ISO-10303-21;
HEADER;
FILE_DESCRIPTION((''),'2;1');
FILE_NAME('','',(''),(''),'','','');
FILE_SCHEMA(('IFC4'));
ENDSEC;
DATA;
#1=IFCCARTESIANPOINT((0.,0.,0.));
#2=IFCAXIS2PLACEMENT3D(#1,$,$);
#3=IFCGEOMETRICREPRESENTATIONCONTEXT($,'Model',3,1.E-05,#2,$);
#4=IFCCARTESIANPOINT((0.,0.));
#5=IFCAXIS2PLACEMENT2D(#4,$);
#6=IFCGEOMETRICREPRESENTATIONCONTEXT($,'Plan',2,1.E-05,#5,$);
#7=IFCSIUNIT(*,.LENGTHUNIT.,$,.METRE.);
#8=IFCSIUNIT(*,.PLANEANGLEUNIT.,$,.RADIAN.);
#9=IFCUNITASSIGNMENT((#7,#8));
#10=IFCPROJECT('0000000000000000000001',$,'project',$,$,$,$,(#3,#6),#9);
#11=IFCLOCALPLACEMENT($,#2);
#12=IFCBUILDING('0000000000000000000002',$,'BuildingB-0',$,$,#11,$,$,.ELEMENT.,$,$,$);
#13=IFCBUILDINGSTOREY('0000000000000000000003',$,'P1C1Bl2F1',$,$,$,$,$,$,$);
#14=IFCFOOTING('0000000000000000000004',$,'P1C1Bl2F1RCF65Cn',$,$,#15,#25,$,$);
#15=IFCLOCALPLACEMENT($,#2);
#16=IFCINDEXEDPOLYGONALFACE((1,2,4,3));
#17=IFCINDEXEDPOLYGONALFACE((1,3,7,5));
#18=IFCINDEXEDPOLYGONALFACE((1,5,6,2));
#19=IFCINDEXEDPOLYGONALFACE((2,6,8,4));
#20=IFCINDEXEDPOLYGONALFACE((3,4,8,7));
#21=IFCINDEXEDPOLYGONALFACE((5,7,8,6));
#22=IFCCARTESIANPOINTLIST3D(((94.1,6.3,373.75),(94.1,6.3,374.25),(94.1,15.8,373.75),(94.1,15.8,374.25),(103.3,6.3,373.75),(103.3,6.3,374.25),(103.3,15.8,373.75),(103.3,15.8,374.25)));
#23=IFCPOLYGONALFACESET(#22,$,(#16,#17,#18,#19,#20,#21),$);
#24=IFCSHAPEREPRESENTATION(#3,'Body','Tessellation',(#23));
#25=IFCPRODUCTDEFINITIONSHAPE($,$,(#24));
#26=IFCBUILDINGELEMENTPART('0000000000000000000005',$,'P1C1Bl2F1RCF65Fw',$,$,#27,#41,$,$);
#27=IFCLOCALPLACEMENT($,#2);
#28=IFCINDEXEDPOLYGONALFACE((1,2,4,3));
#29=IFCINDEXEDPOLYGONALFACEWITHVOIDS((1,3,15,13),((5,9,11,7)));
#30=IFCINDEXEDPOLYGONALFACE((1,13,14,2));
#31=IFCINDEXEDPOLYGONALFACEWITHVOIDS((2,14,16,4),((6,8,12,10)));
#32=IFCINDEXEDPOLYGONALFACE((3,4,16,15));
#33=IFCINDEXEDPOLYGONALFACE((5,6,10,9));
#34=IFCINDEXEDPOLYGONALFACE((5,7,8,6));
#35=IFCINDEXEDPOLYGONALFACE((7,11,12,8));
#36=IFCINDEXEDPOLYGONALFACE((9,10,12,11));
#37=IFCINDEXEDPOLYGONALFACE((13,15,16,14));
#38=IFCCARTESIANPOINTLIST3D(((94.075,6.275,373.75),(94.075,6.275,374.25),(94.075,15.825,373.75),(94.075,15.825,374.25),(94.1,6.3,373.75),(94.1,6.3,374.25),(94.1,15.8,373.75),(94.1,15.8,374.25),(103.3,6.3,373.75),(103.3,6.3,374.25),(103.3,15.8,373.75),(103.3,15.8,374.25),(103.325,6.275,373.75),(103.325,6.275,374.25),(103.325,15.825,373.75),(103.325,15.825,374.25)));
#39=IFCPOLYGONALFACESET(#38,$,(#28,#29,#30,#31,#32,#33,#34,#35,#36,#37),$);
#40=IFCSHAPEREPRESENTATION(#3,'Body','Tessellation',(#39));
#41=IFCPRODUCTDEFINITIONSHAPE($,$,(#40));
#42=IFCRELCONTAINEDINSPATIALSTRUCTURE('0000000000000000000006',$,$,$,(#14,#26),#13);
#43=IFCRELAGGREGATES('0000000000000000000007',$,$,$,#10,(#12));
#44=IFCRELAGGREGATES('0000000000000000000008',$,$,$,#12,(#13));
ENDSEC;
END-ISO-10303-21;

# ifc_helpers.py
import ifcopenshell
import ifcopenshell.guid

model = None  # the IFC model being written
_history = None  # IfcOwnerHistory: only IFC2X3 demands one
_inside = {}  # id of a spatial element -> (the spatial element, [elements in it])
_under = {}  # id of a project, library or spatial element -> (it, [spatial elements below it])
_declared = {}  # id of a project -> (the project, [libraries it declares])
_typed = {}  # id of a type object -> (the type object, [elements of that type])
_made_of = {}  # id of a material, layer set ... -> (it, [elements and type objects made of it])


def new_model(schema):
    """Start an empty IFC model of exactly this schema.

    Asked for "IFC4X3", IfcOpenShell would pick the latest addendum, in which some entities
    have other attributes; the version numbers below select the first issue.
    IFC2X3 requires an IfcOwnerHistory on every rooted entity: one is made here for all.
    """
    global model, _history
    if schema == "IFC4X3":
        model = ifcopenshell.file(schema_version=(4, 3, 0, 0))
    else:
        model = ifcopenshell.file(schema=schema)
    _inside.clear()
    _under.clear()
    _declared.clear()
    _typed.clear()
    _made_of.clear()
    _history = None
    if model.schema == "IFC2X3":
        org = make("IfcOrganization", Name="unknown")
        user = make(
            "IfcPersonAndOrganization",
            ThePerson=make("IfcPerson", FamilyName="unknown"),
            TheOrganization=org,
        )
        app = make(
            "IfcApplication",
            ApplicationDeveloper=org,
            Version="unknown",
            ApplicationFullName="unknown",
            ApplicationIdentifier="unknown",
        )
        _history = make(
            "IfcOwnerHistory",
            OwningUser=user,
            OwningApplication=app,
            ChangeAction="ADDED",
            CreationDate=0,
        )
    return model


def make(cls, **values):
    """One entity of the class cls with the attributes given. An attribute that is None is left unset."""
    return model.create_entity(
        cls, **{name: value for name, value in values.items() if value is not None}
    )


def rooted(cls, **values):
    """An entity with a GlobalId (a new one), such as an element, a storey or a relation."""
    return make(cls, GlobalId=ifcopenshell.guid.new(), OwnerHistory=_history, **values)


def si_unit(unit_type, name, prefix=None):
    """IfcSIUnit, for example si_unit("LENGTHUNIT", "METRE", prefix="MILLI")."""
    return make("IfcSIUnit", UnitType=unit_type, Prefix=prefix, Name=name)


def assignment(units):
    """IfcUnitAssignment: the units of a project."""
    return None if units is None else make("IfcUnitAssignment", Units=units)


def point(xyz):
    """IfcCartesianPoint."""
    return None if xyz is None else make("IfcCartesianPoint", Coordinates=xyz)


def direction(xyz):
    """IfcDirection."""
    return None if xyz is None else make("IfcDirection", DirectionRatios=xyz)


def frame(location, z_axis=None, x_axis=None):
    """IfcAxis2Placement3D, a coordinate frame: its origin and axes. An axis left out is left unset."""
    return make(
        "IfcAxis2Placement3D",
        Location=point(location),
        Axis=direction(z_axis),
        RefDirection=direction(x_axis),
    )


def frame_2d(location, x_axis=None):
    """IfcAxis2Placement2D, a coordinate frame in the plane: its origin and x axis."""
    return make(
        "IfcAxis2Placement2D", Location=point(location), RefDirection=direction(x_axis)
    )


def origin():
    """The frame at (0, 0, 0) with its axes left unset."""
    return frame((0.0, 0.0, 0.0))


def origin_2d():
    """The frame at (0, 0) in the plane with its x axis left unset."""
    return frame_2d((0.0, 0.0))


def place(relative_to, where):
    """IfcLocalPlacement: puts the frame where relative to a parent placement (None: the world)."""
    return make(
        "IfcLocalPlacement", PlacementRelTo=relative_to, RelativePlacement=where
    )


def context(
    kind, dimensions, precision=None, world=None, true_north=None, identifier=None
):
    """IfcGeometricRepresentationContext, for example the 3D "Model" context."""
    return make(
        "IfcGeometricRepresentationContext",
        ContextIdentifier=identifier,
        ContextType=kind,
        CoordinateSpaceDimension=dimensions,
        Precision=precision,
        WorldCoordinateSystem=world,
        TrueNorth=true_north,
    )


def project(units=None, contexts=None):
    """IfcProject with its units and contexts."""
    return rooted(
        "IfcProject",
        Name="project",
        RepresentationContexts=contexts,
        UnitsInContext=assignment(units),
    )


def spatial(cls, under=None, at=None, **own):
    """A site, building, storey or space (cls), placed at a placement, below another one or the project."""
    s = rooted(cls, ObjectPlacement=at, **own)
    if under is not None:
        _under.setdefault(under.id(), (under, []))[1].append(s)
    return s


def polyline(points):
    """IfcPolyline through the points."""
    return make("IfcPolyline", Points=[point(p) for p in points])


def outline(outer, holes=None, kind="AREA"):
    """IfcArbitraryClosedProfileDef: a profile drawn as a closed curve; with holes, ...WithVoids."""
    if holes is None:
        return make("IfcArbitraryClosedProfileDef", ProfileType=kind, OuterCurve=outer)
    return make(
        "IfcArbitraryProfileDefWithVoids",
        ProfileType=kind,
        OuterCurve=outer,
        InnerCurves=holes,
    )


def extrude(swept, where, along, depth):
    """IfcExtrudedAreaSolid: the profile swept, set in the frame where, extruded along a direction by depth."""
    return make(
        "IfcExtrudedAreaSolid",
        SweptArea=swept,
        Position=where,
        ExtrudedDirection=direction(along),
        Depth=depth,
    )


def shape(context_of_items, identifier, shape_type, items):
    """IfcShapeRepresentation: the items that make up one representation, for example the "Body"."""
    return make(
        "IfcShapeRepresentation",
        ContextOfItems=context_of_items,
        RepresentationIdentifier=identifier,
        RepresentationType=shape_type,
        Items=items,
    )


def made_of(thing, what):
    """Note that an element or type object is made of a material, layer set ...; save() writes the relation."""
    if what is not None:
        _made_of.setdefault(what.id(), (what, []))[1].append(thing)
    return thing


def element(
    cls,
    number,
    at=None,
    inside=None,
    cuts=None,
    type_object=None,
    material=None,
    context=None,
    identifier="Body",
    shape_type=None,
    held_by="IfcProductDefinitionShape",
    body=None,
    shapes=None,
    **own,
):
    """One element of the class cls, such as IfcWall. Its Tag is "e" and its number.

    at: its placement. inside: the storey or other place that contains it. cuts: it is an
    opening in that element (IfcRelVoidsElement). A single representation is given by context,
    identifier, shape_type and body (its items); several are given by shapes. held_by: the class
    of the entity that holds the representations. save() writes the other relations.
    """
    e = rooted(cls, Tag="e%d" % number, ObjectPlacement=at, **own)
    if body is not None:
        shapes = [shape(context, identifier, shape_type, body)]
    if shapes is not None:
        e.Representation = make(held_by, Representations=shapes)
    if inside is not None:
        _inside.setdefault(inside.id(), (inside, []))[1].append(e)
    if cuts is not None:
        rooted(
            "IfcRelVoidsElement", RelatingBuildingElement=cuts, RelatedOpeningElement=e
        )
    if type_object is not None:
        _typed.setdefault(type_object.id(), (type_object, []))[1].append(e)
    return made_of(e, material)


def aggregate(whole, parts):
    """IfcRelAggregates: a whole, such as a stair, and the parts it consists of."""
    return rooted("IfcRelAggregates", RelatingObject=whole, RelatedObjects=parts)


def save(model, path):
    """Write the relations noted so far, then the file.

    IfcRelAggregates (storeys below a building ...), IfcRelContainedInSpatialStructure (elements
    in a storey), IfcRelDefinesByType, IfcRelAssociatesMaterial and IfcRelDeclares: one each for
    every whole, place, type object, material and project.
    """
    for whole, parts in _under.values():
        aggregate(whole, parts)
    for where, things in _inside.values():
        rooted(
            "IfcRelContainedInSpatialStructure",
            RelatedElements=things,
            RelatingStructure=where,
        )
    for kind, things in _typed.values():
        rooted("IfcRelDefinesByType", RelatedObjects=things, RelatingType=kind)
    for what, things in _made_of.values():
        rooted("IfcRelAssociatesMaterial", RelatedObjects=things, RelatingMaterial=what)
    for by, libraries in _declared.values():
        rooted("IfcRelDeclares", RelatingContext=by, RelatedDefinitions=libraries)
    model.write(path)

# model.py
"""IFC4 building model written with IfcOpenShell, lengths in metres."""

from ifc_helpers import new_model, si_unit, origin, origin_2d, place, context, project, spatial, polyline, outline, extrude, element, save


model = new_model("IFC4")

# Units and contexts
model_context = context("Model", 3, precision=1e-05, world=origin())
plan_context = context("Plan", 2, precision=1e-05, world=origin_2d())
ifc_project = project(units=[si_unit("LENGTHUNIT", "METRE"), si_unit("PLANEANGLEUNIT", "RADIAN")], contexts=[model_context, plan_context])

# Building, storey
building_placement = place(None, origin())
building = spatial("IfcBuilding", under=ifc_project, at=building_placement, Name="BuildingB-0", CompositionType="ELEMENT")
storey = spatial("IfcBuildingStorey", under=building, Name="P1C1Bl2F1")

# Footing
element("IfcFooting", 1, inside=storey, Name="P1C1Bl2F1RCF65Cn", context=model_context, shape_type="SweptSolid", body=[
    extrude(outline(polyline([(94.1, 15.8, 373.75), (103.3, 15.8, 373.75), (103.3, 6.3, 373.75), (94.1, 6.3, 373.75), (94.1, 15.8, 373.75)])), None, (0.0, 0.0, 1.0), 0.5),
])

# Building element part, opening
building_element_part = element("IfcBuildingElementPart", 2, inside=storey, Name="P1C1Bl2F1RCF65Fw", context=model_context, shape_type="SweptSolid", body=[
    extrude(outline(polyline([(94.075, 15.825, 373.75), (103.325, 15.825, 373.75), (103.325, 6.275, 373.75), (94.075, 6.275, 373.75), (94.075, 15.825, 373.75)])), None, (0.0, 0.0, 1.0), 0.5),
])
element("IfcOpeningElement", 3, inside=storey, cuts=building_element_part, context=model_context, shape_type="SweptSolid", body=[
    extrude(outline(polyline([(94.1, 15.8, 373.75), (103.3, 15.8, 373.75), (103.3, 6.3, 373.75), (94.1, 6.3, 373.75), (94.1, 15.8, 373.75)])), None, (0.0, 0.0, 1.0), 0.5),
])

save(model, "model.ifc")
